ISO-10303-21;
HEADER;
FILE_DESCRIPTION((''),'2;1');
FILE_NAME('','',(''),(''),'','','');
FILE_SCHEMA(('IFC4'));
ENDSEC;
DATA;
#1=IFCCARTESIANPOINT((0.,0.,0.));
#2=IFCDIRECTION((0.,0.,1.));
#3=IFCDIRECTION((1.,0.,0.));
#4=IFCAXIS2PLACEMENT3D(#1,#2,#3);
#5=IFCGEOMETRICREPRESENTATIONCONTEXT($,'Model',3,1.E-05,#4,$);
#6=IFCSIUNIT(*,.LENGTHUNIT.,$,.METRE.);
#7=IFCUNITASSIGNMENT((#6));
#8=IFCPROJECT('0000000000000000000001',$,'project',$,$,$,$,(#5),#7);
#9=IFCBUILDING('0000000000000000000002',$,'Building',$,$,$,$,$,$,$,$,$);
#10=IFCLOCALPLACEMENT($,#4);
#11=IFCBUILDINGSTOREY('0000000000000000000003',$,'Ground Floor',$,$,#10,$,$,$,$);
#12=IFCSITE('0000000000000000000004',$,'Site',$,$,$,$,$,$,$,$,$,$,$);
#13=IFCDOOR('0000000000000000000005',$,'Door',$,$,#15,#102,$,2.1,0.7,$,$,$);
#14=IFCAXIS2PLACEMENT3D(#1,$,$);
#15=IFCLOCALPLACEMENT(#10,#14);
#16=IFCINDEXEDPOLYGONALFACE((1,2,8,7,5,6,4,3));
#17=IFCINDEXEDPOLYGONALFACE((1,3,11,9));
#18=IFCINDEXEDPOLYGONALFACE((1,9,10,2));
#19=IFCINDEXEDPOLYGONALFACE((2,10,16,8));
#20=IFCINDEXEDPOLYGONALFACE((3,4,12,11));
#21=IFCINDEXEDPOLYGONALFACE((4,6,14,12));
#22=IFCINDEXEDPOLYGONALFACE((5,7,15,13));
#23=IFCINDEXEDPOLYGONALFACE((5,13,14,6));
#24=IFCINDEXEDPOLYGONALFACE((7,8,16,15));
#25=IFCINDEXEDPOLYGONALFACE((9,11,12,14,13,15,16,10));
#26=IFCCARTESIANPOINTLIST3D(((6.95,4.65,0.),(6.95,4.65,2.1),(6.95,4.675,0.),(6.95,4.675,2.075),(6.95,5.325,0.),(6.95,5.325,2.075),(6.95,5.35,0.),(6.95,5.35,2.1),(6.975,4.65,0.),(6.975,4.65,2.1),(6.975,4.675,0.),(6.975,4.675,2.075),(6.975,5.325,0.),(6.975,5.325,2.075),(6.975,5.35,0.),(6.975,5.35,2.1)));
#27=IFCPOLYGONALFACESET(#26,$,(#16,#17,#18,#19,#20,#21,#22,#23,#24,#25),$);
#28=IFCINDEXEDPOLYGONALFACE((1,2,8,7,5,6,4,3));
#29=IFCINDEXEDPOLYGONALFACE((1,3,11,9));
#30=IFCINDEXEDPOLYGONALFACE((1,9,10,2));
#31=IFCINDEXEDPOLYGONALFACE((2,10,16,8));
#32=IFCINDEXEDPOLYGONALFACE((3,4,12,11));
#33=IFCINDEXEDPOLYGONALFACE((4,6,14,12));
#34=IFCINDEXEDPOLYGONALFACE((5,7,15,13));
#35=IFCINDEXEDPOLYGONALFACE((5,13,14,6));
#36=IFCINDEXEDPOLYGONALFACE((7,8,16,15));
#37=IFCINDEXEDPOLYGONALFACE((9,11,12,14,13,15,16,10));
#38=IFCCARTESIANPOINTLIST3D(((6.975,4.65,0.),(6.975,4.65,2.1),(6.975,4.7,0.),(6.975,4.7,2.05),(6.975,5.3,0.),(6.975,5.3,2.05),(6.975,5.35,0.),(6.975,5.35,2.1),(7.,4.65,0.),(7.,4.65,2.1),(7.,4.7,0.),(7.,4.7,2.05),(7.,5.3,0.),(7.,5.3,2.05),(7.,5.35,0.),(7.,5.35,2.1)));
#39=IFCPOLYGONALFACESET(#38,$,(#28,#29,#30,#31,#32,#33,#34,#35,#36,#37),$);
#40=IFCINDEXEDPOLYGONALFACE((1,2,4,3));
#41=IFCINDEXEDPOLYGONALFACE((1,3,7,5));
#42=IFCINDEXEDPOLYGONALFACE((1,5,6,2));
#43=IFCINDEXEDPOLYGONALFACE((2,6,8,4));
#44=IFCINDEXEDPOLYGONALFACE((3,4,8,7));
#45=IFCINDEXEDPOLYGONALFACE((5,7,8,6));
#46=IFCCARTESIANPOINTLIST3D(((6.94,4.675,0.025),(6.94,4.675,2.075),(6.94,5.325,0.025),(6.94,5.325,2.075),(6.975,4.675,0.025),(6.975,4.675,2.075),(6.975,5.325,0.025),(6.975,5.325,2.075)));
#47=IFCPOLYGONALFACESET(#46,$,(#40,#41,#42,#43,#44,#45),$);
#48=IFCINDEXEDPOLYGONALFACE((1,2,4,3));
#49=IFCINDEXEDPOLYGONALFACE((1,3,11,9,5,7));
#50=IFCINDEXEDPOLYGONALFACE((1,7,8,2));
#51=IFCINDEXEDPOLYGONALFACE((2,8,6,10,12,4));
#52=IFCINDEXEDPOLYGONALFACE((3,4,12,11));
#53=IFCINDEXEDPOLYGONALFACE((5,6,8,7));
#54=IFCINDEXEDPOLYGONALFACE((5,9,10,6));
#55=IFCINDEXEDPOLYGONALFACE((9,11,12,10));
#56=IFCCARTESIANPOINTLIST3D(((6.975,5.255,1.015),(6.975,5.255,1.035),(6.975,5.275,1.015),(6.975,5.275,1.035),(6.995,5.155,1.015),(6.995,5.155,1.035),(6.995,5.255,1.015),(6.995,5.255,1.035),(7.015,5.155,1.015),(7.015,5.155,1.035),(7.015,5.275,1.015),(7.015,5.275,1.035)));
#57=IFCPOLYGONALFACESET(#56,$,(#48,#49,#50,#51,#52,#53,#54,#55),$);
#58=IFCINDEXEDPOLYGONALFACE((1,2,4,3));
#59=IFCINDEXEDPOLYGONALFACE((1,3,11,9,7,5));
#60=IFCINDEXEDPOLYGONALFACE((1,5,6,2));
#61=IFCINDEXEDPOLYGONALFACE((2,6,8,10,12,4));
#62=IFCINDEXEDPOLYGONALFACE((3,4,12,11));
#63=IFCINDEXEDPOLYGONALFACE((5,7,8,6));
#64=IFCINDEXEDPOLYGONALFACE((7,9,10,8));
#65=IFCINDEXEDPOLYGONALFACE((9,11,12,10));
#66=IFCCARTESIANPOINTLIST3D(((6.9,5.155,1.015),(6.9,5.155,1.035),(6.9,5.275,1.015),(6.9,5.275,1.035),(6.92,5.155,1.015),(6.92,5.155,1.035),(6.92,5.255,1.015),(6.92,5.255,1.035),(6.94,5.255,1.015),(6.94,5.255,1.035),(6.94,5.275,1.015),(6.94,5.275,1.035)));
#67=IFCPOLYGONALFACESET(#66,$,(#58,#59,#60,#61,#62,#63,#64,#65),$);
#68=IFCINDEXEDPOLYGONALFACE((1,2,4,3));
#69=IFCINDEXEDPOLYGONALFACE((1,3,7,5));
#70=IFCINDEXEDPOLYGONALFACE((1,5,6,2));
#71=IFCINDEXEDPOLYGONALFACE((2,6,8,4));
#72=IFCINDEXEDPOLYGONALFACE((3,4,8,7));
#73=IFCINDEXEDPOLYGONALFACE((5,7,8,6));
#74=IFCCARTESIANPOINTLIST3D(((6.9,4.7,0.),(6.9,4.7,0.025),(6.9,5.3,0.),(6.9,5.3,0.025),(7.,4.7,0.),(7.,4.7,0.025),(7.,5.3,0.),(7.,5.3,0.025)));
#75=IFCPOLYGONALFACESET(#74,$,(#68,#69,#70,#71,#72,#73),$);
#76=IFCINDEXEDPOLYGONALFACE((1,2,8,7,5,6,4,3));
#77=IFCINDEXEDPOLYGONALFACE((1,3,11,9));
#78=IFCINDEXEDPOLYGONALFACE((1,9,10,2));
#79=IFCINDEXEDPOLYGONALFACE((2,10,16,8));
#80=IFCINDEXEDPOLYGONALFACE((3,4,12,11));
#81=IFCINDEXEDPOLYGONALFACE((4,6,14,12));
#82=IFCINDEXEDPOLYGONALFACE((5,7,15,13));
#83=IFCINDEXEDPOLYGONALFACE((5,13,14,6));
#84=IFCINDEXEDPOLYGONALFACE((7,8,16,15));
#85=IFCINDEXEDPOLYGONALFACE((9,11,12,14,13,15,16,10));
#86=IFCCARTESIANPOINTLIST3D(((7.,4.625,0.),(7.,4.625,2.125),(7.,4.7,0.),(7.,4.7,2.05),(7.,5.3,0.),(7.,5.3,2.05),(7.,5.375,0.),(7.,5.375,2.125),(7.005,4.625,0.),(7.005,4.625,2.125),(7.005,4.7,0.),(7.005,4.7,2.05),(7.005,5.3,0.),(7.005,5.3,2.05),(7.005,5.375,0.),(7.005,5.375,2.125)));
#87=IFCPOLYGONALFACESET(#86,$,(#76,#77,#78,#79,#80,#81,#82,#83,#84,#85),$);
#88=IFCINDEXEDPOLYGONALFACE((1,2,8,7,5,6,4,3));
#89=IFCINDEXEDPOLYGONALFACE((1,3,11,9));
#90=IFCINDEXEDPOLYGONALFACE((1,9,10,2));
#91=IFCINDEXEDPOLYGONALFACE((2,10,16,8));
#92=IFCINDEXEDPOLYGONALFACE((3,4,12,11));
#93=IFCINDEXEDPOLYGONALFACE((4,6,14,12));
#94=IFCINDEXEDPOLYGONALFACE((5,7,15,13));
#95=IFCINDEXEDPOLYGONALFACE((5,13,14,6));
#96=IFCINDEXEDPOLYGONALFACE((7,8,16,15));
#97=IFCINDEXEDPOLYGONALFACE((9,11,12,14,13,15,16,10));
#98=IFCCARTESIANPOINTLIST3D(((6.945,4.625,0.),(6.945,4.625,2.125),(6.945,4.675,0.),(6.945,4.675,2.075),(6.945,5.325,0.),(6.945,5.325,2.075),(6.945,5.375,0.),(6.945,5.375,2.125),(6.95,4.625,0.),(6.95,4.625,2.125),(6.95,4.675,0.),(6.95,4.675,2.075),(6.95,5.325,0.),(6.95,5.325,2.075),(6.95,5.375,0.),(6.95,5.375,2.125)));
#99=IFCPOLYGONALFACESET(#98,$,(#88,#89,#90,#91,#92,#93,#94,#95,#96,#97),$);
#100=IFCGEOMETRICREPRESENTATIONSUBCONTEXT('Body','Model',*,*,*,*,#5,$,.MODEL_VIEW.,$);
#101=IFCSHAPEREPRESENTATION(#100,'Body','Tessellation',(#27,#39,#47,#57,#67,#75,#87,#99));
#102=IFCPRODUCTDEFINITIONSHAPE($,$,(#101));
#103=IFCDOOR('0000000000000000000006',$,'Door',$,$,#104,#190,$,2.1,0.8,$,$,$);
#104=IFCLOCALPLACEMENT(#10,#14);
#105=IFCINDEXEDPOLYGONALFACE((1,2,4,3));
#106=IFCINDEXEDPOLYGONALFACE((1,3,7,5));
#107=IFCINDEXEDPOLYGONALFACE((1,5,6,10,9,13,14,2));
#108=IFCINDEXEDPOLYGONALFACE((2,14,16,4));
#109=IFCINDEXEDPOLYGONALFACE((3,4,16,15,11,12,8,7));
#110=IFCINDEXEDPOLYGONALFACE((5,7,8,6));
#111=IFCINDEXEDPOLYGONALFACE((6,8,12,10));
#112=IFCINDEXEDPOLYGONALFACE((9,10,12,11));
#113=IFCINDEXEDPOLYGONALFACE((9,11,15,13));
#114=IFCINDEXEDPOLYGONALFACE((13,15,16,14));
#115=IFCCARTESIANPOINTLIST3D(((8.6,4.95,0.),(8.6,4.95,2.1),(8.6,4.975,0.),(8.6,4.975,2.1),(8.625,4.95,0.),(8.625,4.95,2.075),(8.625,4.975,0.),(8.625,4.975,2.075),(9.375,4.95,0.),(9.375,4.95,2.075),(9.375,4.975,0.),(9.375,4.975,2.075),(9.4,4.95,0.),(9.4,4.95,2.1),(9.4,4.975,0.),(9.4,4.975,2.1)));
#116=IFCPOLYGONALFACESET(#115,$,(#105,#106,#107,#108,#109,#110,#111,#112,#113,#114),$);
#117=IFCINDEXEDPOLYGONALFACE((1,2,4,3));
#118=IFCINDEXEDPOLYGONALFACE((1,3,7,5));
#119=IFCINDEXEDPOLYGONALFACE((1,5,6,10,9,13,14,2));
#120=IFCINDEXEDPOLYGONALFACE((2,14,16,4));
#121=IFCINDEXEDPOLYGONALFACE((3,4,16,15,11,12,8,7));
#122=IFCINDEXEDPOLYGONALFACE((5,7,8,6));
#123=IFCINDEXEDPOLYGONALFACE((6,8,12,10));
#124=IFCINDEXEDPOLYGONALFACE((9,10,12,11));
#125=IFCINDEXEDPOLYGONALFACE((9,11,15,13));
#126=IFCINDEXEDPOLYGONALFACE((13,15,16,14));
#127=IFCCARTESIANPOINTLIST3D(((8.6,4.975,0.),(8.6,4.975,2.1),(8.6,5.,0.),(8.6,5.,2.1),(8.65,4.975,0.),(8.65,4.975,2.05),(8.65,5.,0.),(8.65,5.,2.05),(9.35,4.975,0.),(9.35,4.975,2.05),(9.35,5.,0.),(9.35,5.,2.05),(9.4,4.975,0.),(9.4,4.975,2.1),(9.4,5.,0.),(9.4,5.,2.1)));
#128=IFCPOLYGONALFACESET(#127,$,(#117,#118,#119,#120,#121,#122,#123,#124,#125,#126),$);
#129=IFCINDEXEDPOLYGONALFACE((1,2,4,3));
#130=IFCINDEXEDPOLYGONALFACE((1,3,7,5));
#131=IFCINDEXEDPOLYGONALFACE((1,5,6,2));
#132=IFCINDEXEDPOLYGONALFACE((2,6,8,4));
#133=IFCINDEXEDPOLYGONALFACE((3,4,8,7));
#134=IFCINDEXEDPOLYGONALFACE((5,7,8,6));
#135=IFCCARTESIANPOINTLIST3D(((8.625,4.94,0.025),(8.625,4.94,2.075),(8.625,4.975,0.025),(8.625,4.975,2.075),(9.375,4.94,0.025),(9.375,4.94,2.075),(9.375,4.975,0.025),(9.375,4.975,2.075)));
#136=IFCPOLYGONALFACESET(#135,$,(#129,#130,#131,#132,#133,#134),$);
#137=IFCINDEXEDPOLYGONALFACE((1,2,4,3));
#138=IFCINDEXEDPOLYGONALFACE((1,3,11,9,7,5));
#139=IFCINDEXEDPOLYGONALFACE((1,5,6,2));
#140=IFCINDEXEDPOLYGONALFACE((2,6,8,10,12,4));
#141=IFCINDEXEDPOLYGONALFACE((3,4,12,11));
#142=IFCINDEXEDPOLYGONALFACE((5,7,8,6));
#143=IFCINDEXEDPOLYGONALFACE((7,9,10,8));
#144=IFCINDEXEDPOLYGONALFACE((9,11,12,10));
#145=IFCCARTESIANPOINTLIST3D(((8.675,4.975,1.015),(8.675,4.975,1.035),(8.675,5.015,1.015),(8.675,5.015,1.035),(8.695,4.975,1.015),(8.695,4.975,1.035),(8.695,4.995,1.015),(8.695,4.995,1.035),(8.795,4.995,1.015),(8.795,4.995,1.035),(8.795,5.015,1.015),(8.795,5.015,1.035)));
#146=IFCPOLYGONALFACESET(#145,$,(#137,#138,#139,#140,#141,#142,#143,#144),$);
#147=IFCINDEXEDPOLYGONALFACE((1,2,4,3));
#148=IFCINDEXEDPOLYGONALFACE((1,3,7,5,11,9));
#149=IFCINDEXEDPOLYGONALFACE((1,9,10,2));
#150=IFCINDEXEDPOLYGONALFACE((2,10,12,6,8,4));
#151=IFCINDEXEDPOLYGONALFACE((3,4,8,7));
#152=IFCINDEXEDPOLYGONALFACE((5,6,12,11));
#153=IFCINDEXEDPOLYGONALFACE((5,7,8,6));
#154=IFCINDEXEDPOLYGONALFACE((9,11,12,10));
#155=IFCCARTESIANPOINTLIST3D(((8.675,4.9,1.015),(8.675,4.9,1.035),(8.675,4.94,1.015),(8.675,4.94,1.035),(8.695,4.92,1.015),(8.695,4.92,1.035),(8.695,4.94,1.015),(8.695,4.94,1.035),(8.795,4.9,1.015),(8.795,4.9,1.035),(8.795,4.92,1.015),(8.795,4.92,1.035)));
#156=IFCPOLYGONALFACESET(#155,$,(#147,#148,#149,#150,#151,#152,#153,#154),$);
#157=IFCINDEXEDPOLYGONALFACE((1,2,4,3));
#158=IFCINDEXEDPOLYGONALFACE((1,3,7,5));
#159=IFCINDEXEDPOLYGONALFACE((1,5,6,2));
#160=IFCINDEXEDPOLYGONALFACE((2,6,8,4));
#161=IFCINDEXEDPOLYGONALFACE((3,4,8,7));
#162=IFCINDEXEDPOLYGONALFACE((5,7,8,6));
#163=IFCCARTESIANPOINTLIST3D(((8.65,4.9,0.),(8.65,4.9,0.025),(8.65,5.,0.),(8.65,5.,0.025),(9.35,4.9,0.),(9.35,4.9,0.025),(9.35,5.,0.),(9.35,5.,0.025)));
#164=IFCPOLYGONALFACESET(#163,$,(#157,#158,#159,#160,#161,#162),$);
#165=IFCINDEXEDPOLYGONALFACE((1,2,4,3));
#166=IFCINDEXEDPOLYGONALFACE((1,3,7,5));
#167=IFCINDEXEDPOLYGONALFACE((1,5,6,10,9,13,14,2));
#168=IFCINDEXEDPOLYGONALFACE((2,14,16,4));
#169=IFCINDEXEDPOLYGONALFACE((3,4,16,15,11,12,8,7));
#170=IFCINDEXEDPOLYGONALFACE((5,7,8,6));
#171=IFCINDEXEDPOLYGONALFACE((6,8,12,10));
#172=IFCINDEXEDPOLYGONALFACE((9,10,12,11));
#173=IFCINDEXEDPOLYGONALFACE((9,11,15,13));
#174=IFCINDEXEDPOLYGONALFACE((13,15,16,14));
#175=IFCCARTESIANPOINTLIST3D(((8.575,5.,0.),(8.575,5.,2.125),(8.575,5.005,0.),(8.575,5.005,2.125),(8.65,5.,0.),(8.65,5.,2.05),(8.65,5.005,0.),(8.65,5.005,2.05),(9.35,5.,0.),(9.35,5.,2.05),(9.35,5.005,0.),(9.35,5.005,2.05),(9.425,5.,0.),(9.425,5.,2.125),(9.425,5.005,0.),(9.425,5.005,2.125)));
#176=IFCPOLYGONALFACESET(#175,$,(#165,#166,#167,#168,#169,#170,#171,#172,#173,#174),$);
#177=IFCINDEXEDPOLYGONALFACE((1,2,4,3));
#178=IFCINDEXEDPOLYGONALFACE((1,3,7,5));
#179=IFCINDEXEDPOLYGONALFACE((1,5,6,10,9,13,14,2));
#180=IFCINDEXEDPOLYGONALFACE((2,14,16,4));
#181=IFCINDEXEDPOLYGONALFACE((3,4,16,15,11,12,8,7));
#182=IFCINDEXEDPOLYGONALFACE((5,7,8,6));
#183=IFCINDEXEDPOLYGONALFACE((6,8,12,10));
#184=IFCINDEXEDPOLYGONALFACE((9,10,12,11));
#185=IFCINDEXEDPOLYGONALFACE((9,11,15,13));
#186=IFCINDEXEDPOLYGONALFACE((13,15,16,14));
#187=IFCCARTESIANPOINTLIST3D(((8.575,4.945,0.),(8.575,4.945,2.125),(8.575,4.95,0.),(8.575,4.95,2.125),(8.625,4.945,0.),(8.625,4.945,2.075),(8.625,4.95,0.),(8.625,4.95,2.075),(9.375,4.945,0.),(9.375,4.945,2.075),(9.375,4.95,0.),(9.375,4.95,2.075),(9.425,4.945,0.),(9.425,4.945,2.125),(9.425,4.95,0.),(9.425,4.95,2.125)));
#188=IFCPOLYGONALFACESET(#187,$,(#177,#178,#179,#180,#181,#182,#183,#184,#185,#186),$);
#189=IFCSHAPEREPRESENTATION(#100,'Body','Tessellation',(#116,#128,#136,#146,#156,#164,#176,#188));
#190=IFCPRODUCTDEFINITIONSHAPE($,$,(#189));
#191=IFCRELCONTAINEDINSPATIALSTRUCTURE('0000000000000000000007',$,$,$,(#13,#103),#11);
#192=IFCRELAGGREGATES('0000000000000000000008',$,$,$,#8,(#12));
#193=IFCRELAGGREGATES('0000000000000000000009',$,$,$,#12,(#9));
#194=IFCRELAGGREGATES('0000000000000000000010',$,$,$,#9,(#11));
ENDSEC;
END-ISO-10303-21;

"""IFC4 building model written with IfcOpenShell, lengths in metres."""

from ifc_helpers import new_model, si_unit, frame, origin_with_axes, place, context, subcontext, project, spatial, line, indexed_curve, outline, extrude, element, save


model = new_model("IFC4")

# Units and contexts
model_context = context("Model", 3, precision=1e-05, world=origin_with_axes())
body_context = subcontext(model_context, "Body", "Model", "MODEL_VIEW")
ifc_project = project(units=[si_unit("LENGTHUNIT", "METRE")], contexts=[model_context])

# Site, building, storey
site = spatial("IfcSite", under=ifc_project, Name="Site")
building = spatial("IfcBuilding", under=site, Name="Building")
storey_placement = place(None, origin_with_axes())
storey = spatial("IfcBuildingStorey", under=building, at=storey_placement, Name="Ground Floor")

# Doors
door_1_placement = place(storey_placement, frame((7.0, 4.65, 0.0), z_axis=(0.0, 0.0, 1.0), x_axis=(0.0, 1.0, 0.0)))
element("IfcDoor", 1, at=door_1_placement, inside=storey, Name="Door", OverallHeight=2.1, OverallWidth=0.7, context=body_context, shape_type="SweptSolid", body=[
    extrude(outline(indexed_curve([(0.0, 0.0), (0.0, 2.1), (0.7, 2.1), (0.7, 0.0), (0.675, 0.0), (0.675, 2.075), (0.025, 2.075), (0.025, 0.0)], segments=[line(1, 2, 3, 4, 5, 6, 7, 8, 1)])), frame((0.0, 0.025, 0.0), z_axis=(0.0, -1.0, 0.0), x_axis=(1.0, 0.0, 0.0)), (0.0, 0.0, -1.0), 0.025),
    extrude(outline(indexed_curve([(0.0, 0.0), (0.0, 2.1), (0.7, 2.1), (0.7, 0.0), (0.65, 0.0), (0.65, 2.05), (0.05, 2.05), (0.05, 0.0)], segments=[line(1, 2, 3, 4, 5, 6, 7, 8, 1)])), frame((0.0, 0.0, 0.0), z_axis=(0.0, -1.0, 0.0), x_axis=(1.0, 0.0, 0.0)), (0.0, 0.0, -1.0), 0.025),
    extrude(outline(indexed_curve([(0.0, 0.0), (0.65, 0.0), (0.65, 0.035), (0.0, 0.035)], segments=[line(1, 2, 3, 4, 1)])), frame((0.025, 0.025, 0.025), z_axis=(0.0, 0.0, 1.0), x_axis=(1.0, 0.0, 0.0)), (0.0, 0.0, 1.0), 2.05),
    extrude(outline(indexed_curve([(0.0, 0.0), (0.0, -0.04), (-0.12, -0.04), (-0.12, -0.02), (-0.02, -0.02), (-0.02, 0.0)], segments=[line(1, 2, 3, 4, 5, 6, 1)])), frame((0.625, 0.025, 1.015), z_axis=(0.0, 0.0, 1.0), x_axis=(1.0, 0.0, 0.0)), (0.0, 0.0, 1.0), 0.02),
    extrude(outline(indexed_curve([(0.0, 0.0), (0.0, 0.04), (-0.12, 0.04), (-0.12, 0.02), (-0.02, 0.02), (-0.02, 0.0)], segments=[line(1, 2, 3, 4, 5, 6, 1)])), frame((0.625, 0.06, 1.015), z_axis=(0.0, 0.0, 1.0), x_axis=(1.0, 0.0, 0.0)), (0.0, 0.0, 1.0), 0.02),
    extrude(outline(indexed_curve([(0.0, 0.0), (0.6, 0.0), (0.6, 0.1), (0.0, 0.1)], segments=[line(1, 2, 3, 4, 1)])), frame((0.05, 0.0, 0.0), z_axis=(0.0, 0.0, 1.0), x_axis=(1.0, 0.0, 0.0)), (0.0, 0.0, 1.0), 0.025),
    extrude(outline(indexed_curve([(0.0, 0.0), (0.0, 2.125), (0.75, 2.125), (0.75, 0.0), (0.675, 0.0), (0.675, 2.05), (0.075, 2.05), (0.075, 0.0)], segments=[line(1, 2, 3, 4, 5, 6, 7, 8, 1)])), frame((-0.025, -0.005, 0.0), z_axis=(0.0, -1.0, 0.0), x_axis=(1.0, 0.0, 0.0)), (0.0, 0.0, -1.0), 0.005),
    extrude(outline(indexed_curve([(0.0, 0.0), (0.0, 2.125), (0.75, 2.125), (0.75, 0.0), (0.7, 0.0), (0.7, 2.075), (0.05, 2.075), (0.05, 0.0)], segments=[line(1, 2, 3, 4, 5, 6, 7, 8, 1)])), frame((-0.025, 0.05, 0.0), z_axis=(0.0, -1.0, 0.0), x_axis=(1.0, 0.0, 0.0)), (0.0, 0.0, -1.0), 0.005),
])
door_2_placement = place(storey_placement, frame((9.4, 5.0, 0.0), z_axis=(0.0, 0.0, 1.0), x_axis=(-1.0, 0.0, 0.0)))
element("IfcDoor", 2, at=door_2_placement, inside=storey, Name="Door", OverallHeight=2.1, OverallWidth=0.8, context=body_context, shape_type="SweptSolid", body=[
    extrude(outline(indexed_curve([(0.0, 0.0), (0.0, 2.1), (0.8, 2.1), (0.8, 0.0), (0.775, 0.0), (0.775, 2.075), (0.025, 2.075), (0.025, 0.0)], segments=[line(1, 2, 3, 4, 5, 6, 7, 8, 1)])), frame((0.0, 0.025, 0.0), z_axis=(0.0, -1.0, 0.0), x_axis=(1.0, 0.0, 0.0)), (0.0, 0.0, -1.0), 0.025),
    extrude(outline(indexed_curve([(0.0, 0.0), (0.0, 2.1), (0.8, 2.1), (0.8, 0.0), (0.75, 0.0), (0.75, 2.05), (0.05, 2.05), (0.05, 0.0)], segments=[line(1, 2, 3, 4, 5, 6, 7, 8, 1)])), frame((0.0, 0.0, 0.0), z_axis=(0.0, -1.0, 0.0), x_axis=(1.0, 0.0, 0.0)), (0.0, 0.0, -1.0), 0.025),
    extrude(outline(indexed_curve([(0.0, 0.0), (0.75, 0.0), (0.75, 0.035), (0.0, 0.035)], segments=[line(1, 2, 3, 4, 1)])), frame((0.025, 0.025, 0.025), z_axis=(0.0, 0.0, 1.0), x_axis=(1.0, 0.0, 0.0)), (0.0, 0.0, 1.0), 2.05),
    extrude(outline(indexed_curve([(0.0, 0.0), (0.0, -0.04), (-0.12, -0.04), (-0.12, -0.02), (-0.02, -0.02), (-0.02, 0.0)], segments=[line(1, 2, 3, 4, 5, 6, 1)])), frame((0.725, 0.025, 1.015), z_axis=(0.0, 0.0, 1.0), x_axis=(1.0, 0.0, 0.0)), (0.0, 0.0, 1.0), 0.02),
    extrude(outline(indexed_curve([(0.0, 0.0), (0.0, 0.04), (-0.12, 0.04), (-0.12, 0.02), (-0.02, 0.02), (-0.02, 0.0)], segments=[line(1, 2, 3, 4, 5, 6, 1)])), frame((0.725, 0.06, 1.015), z_axis=(0.0, 0.0, 1.0), x_axis=(1.0, 0.0, 0.0)), (0.0, 0.0, 1.0), 0.02),
    extrude(outline(indexed_curve([(0.0, 0.0), (0.7, 0.0), (0.7, 0.1), (0.0, 0.1)], segments=[line(1, 2, 3, 4, 1)])), frame((0.05, 0.0, 0.0), z_axis=(0.0, 0.0, 1.0), x_axis=(1.0, 0.0, 0.0)), (0.0, 0.0, 1.0), 0.025),
    extrude(outline(indexed_curve([(0.0, 0.0), (0.0, 2.125), (0.85, 2.125), (0.85, 0.0), (0.775, 0.0), (0.775, 2.05), (0.075, 2.05), (0.075, 0.0)], segments=[line(1, 2, 3, 4, 5, 6, 7, 8, 1)])), frame((-0.025, -0.005, 0.0), z_axis=(0.0, -1.0, 0.0), x_axis=(1.0, 0.0, 0.0)), (0.0, 0.0, -1.0), 0.005),
    extrude(outline(indexed_curve([(0.0, 0.0), (0.0, 2.125), (0.85, 2.125), (0.85, 0.0), (0.8, 0.0), (0.8, 2.075), (0.05, 2.075), (0.05, 0.0)], segments=[line(1, 2, 3, 4, 5, 6, 7, 8, 1)])), frame((-0.025, 0.05, 0.0), z_axis=(0.0, -1.0, 0.0), x_axis=(1.0, 0.0, 0.0)), (0.0, 0.0, -1.0), 0.005),
])

save(model, "model.ifc")
